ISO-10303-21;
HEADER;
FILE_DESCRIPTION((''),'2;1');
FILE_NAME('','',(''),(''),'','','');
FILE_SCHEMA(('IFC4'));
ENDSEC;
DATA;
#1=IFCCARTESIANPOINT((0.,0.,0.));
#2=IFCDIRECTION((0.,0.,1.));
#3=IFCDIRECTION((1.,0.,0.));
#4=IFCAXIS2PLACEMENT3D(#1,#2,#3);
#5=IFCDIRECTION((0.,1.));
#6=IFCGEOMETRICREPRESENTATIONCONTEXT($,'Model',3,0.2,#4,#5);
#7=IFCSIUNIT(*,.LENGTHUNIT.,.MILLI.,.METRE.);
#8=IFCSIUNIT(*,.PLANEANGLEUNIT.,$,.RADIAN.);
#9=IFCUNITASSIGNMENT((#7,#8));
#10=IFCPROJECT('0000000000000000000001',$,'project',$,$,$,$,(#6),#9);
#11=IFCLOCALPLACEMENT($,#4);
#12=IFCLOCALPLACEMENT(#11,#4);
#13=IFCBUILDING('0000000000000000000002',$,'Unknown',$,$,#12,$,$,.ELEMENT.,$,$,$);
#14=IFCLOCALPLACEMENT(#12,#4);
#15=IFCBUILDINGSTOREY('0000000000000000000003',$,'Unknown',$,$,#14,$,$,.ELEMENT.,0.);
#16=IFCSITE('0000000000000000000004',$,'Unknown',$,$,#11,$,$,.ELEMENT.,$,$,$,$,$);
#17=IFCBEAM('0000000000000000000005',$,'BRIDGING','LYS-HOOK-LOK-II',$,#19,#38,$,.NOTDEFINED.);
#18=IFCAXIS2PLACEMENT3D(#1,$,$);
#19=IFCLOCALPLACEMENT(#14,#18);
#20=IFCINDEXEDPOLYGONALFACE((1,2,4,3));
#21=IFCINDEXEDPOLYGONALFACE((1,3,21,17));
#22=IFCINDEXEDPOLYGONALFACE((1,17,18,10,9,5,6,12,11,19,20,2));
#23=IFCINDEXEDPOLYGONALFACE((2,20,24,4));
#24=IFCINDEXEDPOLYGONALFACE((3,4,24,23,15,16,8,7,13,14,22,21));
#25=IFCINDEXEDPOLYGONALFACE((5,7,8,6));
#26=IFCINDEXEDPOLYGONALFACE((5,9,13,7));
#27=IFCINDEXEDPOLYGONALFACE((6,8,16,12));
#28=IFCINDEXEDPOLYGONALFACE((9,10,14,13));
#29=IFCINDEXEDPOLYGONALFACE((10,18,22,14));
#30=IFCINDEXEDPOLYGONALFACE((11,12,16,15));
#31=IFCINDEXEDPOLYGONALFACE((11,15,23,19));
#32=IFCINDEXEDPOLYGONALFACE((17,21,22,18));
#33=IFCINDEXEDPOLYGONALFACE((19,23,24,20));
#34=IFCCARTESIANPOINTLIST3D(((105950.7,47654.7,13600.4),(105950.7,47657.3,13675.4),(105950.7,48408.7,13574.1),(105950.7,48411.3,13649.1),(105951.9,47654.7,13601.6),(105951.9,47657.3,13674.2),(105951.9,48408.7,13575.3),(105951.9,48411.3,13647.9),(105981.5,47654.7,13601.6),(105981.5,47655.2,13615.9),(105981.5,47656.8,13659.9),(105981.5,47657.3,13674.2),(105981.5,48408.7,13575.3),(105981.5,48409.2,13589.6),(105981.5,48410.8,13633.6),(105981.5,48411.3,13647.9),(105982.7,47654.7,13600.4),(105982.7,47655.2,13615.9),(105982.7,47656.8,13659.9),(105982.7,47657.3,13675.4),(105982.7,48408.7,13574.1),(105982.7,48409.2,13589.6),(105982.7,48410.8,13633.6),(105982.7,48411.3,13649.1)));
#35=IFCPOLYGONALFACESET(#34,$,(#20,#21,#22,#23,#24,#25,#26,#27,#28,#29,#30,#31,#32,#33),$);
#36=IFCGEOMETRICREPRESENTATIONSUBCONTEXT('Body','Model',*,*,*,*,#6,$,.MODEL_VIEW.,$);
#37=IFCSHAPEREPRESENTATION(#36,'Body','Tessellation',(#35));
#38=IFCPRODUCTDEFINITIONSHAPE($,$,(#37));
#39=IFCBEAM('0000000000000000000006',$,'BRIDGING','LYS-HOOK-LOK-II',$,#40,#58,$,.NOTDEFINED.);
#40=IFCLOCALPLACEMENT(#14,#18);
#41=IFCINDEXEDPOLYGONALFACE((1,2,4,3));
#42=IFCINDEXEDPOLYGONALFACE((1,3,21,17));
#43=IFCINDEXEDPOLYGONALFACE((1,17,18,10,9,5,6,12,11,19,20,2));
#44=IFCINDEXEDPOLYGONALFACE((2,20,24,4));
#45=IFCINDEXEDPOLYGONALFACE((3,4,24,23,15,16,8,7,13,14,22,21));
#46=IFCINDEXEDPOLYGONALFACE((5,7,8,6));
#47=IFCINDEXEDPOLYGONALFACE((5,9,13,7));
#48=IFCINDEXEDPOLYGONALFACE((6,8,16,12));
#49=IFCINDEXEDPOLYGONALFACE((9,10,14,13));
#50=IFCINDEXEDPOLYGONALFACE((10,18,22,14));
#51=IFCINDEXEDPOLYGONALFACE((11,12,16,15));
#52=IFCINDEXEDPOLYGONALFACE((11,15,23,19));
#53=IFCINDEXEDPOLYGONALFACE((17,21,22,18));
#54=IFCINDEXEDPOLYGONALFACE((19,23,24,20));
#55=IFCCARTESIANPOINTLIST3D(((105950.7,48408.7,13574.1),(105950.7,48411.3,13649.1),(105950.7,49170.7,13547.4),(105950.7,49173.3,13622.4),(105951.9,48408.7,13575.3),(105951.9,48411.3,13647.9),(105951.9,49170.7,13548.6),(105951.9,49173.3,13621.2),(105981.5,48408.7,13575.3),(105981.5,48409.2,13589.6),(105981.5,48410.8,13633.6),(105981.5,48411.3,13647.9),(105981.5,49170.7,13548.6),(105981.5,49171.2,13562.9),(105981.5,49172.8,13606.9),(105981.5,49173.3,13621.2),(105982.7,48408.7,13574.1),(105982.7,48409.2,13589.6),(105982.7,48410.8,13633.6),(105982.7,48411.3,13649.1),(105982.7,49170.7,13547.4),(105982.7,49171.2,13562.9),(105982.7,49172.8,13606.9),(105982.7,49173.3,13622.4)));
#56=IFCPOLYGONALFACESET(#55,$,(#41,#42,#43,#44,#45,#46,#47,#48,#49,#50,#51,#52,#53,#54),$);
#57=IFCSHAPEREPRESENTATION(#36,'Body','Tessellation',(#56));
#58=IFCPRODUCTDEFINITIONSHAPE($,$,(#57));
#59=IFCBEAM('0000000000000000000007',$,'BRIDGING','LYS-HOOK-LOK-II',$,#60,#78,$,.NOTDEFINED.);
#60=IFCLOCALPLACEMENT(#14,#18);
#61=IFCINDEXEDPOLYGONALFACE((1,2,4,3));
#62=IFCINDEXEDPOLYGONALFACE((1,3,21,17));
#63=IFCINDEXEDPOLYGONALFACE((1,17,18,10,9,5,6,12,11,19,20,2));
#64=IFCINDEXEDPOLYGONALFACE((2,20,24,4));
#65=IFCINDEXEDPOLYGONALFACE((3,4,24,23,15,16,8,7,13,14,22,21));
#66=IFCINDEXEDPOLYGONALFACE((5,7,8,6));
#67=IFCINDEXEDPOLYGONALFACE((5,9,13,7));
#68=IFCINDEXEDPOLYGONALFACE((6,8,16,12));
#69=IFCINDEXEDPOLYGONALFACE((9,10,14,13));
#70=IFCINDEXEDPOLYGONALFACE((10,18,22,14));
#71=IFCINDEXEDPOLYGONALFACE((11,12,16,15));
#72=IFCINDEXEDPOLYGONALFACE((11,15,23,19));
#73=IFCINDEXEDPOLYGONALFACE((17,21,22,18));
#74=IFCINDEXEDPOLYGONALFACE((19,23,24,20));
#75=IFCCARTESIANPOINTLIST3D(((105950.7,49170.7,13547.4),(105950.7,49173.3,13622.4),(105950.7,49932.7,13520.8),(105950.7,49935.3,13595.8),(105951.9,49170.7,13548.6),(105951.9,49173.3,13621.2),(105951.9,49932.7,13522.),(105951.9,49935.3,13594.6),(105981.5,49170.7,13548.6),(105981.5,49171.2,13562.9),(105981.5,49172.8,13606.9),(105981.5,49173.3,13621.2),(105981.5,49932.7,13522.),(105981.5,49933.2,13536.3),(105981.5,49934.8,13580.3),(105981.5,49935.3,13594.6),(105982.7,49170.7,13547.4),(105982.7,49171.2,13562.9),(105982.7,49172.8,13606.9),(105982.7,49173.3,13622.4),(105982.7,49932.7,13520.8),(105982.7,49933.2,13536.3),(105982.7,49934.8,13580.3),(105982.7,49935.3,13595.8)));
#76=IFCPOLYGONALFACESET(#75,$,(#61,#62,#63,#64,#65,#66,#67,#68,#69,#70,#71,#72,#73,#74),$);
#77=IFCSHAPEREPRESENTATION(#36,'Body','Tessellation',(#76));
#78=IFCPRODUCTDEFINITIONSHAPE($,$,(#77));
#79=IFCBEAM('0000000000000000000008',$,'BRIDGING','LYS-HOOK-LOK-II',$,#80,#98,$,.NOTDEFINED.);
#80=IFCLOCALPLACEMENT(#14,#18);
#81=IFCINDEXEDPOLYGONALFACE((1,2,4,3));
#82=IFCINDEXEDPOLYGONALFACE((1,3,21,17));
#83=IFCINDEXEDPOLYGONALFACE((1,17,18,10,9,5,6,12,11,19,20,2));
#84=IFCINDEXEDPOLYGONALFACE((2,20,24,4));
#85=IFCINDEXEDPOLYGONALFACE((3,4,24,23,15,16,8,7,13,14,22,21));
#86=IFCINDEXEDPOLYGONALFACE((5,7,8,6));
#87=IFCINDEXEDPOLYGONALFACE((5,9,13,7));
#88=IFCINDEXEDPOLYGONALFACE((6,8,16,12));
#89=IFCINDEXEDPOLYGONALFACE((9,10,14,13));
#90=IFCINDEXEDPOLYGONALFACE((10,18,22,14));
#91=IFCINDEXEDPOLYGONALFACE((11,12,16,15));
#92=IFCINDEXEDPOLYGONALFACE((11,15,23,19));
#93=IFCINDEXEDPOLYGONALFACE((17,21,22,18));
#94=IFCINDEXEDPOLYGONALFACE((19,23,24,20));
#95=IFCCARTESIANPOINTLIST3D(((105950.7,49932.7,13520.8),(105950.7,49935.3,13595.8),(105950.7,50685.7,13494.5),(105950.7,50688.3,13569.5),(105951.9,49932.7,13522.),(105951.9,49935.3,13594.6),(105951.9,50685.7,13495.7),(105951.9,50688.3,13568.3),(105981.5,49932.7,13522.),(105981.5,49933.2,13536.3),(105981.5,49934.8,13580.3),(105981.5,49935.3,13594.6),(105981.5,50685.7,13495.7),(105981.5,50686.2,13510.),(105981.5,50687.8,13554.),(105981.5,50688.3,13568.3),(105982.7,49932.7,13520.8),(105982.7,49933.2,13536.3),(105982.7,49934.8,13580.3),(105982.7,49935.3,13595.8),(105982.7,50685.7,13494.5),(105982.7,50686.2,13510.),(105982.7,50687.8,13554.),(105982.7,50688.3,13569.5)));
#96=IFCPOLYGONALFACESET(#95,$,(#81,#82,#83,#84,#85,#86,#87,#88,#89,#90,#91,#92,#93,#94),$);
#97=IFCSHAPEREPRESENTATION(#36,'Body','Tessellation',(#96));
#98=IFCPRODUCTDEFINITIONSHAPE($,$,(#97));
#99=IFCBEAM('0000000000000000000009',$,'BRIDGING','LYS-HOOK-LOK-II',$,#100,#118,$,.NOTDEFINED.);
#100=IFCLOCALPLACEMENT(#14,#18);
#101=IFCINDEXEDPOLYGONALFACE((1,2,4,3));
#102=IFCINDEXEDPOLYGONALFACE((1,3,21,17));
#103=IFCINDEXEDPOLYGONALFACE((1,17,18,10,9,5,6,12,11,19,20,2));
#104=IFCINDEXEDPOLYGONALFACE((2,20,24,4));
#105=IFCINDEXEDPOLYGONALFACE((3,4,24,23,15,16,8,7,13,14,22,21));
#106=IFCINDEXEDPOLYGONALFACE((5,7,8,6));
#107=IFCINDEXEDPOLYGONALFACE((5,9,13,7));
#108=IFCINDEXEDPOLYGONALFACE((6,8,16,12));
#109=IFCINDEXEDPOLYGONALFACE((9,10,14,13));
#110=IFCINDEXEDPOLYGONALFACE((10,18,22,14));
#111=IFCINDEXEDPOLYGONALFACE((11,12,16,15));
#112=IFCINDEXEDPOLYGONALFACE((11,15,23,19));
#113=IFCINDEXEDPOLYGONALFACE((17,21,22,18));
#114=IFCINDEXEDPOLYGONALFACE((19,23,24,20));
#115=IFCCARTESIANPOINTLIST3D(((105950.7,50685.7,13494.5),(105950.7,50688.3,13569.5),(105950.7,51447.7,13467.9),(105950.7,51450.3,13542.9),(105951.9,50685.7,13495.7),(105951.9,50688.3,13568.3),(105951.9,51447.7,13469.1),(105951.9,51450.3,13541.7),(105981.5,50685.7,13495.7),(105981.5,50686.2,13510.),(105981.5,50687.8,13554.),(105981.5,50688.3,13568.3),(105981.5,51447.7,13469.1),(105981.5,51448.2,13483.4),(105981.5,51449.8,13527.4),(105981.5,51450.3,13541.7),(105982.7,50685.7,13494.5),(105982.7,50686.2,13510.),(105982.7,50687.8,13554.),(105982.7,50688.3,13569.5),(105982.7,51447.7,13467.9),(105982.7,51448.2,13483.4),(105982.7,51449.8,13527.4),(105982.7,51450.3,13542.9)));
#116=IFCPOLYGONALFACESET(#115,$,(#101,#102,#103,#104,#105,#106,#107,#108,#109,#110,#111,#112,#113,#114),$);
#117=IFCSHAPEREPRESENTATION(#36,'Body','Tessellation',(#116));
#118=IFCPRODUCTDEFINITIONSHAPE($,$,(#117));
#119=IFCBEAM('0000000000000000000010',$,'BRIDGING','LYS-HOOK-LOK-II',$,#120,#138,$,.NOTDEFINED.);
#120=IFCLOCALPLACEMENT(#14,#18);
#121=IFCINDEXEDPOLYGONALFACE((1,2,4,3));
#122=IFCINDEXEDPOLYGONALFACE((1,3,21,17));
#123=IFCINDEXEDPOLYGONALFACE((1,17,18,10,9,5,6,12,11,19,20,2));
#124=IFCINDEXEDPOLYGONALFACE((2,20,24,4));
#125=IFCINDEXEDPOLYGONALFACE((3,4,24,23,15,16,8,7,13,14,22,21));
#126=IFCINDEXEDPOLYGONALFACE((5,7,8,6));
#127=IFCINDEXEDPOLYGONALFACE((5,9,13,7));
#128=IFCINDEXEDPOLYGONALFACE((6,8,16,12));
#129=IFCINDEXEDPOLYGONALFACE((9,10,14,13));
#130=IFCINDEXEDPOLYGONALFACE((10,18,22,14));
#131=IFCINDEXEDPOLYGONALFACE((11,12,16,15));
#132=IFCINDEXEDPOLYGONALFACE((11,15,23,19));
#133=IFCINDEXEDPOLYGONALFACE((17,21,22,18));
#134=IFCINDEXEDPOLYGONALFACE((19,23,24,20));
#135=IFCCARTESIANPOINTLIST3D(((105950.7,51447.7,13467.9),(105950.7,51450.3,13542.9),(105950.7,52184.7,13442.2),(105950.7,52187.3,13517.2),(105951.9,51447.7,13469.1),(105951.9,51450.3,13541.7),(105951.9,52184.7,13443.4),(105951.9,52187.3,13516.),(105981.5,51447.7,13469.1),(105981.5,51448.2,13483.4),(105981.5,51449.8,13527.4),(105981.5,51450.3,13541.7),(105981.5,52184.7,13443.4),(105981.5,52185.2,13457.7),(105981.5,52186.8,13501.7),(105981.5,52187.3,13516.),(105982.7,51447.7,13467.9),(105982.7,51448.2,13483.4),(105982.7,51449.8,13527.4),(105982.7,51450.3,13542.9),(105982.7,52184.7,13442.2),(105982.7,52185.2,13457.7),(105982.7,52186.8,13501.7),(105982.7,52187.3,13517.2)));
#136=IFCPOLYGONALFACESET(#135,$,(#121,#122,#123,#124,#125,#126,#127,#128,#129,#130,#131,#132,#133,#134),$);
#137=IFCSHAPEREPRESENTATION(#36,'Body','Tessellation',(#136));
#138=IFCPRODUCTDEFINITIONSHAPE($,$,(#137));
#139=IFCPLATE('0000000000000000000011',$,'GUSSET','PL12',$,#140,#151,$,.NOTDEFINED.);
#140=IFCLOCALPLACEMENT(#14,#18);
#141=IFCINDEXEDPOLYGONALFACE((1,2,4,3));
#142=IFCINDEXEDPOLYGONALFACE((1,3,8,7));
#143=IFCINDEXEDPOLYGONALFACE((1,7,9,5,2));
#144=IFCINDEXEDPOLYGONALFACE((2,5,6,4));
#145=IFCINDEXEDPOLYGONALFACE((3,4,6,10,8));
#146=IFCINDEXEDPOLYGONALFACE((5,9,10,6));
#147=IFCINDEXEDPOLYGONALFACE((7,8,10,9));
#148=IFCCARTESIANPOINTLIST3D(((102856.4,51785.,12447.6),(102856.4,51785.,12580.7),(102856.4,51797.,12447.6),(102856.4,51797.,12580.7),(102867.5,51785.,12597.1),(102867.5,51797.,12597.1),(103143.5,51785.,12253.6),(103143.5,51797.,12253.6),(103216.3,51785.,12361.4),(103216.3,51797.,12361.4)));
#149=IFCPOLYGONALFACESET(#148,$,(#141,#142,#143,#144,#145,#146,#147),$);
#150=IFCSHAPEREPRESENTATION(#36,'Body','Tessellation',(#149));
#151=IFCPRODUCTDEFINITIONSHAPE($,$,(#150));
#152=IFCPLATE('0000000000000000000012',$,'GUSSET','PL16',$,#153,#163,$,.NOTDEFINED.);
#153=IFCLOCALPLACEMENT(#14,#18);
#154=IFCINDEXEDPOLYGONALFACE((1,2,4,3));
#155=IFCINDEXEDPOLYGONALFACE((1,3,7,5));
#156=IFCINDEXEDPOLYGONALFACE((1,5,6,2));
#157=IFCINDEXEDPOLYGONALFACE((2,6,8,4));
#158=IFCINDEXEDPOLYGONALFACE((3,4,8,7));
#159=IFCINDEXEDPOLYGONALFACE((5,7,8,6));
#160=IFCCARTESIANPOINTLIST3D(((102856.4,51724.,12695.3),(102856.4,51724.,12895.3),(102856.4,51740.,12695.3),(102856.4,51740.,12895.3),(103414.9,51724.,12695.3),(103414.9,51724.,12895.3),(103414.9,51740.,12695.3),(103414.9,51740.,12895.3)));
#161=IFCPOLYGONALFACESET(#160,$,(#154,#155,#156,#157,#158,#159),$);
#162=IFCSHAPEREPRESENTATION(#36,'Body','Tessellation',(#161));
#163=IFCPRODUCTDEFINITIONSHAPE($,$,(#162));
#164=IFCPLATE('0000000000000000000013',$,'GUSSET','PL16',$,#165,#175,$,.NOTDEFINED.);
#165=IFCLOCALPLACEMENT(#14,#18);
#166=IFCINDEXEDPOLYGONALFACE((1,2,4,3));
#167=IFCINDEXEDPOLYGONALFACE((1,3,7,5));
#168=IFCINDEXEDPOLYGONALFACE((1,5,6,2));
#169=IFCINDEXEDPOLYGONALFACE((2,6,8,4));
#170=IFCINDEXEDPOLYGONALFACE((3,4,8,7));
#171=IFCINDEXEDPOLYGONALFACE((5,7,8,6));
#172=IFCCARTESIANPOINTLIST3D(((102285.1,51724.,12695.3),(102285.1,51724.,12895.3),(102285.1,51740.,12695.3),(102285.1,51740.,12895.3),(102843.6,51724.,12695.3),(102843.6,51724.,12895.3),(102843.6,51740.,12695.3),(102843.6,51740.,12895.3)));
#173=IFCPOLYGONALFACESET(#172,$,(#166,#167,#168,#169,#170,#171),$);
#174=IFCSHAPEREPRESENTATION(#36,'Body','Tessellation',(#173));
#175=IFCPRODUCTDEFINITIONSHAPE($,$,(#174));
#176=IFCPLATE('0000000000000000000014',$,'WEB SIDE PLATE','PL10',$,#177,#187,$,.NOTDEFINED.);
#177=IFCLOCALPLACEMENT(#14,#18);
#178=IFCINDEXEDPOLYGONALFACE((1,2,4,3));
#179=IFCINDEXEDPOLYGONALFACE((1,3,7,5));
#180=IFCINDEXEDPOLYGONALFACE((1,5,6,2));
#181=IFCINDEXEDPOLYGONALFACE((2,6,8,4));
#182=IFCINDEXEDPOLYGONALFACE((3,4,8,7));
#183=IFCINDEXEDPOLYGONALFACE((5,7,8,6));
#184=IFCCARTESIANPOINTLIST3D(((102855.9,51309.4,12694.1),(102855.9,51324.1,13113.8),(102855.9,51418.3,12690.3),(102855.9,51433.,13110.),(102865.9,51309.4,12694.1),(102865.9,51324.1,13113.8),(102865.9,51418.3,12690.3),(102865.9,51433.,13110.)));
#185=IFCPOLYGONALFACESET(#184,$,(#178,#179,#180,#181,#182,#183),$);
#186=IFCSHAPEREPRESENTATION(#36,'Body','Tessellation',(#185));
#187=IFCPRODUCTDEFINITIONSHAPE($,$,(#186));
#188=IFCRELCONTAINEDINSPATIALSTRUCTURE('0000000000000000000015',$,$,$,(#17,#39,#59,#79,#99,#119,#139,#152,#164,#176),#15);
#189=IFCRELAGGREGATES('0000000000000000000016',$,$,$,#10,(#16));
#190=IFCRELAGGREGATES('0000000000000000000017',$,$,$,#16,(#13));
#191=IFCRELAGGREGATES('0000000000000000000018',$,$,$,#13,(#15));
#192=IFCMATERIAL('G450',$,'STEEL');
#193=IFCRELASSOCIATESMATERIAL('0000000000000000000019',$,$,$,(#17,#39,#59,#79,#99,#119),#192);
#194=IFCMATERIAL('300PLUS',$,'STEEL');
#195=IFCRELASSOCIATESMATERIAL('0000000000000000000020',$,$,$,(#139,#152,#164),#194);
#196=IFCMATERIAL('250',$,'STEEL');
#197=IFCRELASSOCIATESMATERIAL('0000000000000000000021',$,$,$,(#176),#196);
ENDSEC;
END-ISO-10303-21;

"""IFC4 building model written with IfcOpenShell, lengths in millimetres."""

from ifc_helpers import new_model, si_unit, direction, frame, origin_with_axes, place, context, subcontext, project, spatial, line, indexed_curve, outline, extrude, material, element, save


model = new_model("IFC4")

# Units and contexts
model_context = context("Model", 3, precision=0.2, world=origin_with_axes(), true_north=direction((0.0, 1.0)))
body_context = subcontext(model_context, "Body", "Model", "MODEL_VIEW")
ifc_project = project(units=[si_unit("LENGTHUNIT", "METRE", prefix="MILLI"), si_unit("PLANEANGLEUNIT", "RADIAN")], contexts=[model_context])

# Site, building, storey
site_placement = place(None, origin_with_axes())
site = spatial("IfcSite", under=ifc_project, at=site_placement, Name="Unknown", CompositionType="ELEMENT")
building_placement = place(site_placement, origin_with_axes())
building = spatial("IfcBuilding", under=site, at=building_placement, Name="Unknown", CompositionType="ELEMENT")
storey_placement = place(building_placement, origin_with_axes())
storey = spatial("IfcBuildingStorey", under=building, at=storey_placement, Name="Unknown", CompositionType="ELEMENT", Elevation=0.0)

# Shared definitions
ifc_material_1 = material(Name="300PLUS", Category="STEEL")
ifc_material_2 = material(Name="G450", Category="STEEL")

# Beams
beam_1_placement = place(storey_placement, frame((105966.7, 47656.0, 13637.9), z_axis=(1.0, 0.0, 0.0), x_axis=(0.0, 0.999392, -0.034859)))
element("IfcBeam", 1, at=beam_1_placement, inside=storey, material=ifc_material_2, Name="BRIDGING", Description="LYS-HOOK-LOK-II", PredefinedType="NOTDEFINED", context=body_context, shape_type="SolidModel", body=[
    extrude(outline(indexed_curve([(16.0, -37.5), (16.0, -22.0), (14.8, -22.0), (14.8, -36.3), (-14.8, -36.3), (-14.8, 36.3), (14.8, 36.3), (14.8, 22.0), (16.0, 22.0), (16.0, 37.5), (-16.0, 37.5), (-16.0, -37.5)], segments=[line(1, 2, 3, 4, 5, 6, 7, 8, 9, 10, 11, 12, 1)])), frame((0.0, 0.0, 0.0), z_axis=(-1.0, 0.0, 0.0), x_axis=(0.0, 0.0, 1.0)), (0.0, 0.0, -1.0), 754.5),
])
beam_2_placement = place(storey_placement, frame((105966.7, 48410.0, 13611.6), z_axis=(1.0, 0.0, 0.0), x_axis=(0.0, 0.999387, -0.035018)))
element("IfcBeam", 2, at=beam_2_placement, inside=storey, material=ifc_material_2, Name="BRIDGING", Description="LYS-HOOK-LOK-II", PredefinedType="NOTDEFINED", context=body_context, shape_type="SolidModel", body=[
    extrude(outline(indexed_curve([(16.0, -37.5), (16.0, -22.0), (14.8, -22.0), (14.8, -36.3), (-14.8, -36.3), (-14.8, 36.3), (14.8, 36.3), (14.8, 22.0), (16.0, 22.0), (16.0, 37.5), (-16.0, 37.5), (-16.0, -37.5)], segments=[line(1, 2, 3, 4, 5, 6, 7, 8, 9, 10, 11, 12, 1)])), frame((0.0, 0.0, 0.0), z_axis=(-1.0, 0.0, 0.0), x_axis=(0.0, 0.0, 1.0)), (0.0, 0.0, -1.0), 762.5),
])
beam_3_placement = place(storey_placement, frame((105966.7, 49172.0, 13584.9), z_axis=(1.0, 0.0, 0.0), x_axis=(0.0, 0.999391, -0.034887)))
element("IfcBeam", 3, at=beam_3_placement, inside=storey, material=ifc_material_2, Name="BRIDGING", Description="LYS-HOOK-LOK-II", PredefinedType="NOTDEFINED", context=body_context, shape_type="SolidModel", body=[
    extrude(outline(indexed_curve([(16.0, -37.5), (16.0, -22.0), (14.8, -22.0), (14.8, -36.3), (-14.8, -36.3), (-14.8, 36.3), (14.8, 36.3), (14.8, 22.0), (16.0, 22.0), (16.0, 37.5), (-16.0, 37.5), (-16.0, -37.5)], segments=[line(1, 2, 3, 4, 5, 6, 7, 8, 9, 10, 11, 12, 1)])), frame((0.0, 0.0, 0.0), z_axis=(-1.0, 0.0, 0.0), x_axis=(0.0, 0.0, 1.0)), (0.0, 0.0, -1.0), 762.5),
])
beam_4_placement = place(storey_placement, frame((105966.7, 49934.0, 13558.3), z_axis=(1.0, 0.0, 0.0), x_axis=(0.0, 0.999391, -0.034906)))
element("IfcBeam", 4, at=beam_4_placement, inside=storey, material=ifc_material_2, Name="BRIDGING", Description="LYS-HOOK-LOK-II", PredefinedType="NOTDEFINED", context=body_context, shape_type="SolidModel", body=[
    extrude(outline(indexed_curve([(16.0, -37.5), (16.0, -22.0), (14.8, -22.0), (14.8, -36.3), (-14.8, -36.3), (-14.8, 36.3), (14.8, 36.3), (14.8, 22.0), (16.0, 22.0), (16.0, 37.5), (-16.0, 37.5), (-16.0, -37.5)], segments=[line(1, 2, 3, 4, 5, 6, 7, 8, 9, 10, 11, 12, 1)])), frame((0.0, 0.0, 0.0), z_axis=(-1.0, 0.0, 0.0), x_axis=(0.0, 0.0, 1.0)), (0.0, 0.0, -1.0), 753.5),
])
beam_5_placement = place(storey_placement, frame((105966.7, 50687.0, 13532.0), z_axis=(1.0, 0.0, 0.0), x_axis=(0.0, 0.999391, -0.034887)))
element("IfcBeam", 5, at=beam_5_placement, inside=storey, material=ifc_material_2, Name="BRIDGING", Description="LYS-HOOK-LOK-II", PredefinedType="NOTDEFINED", context=body_context, shape_type="SolidModel", body=[
    extrude(outline(indexed_curve([(16.0, -37.5), (16.0, -22.0), (14.8, -22.0), (14.8, -36.3), (-14.8, -36.3), (-14.8, 36.3), (14.8, 36.3), (14.8, 22.0), (16.0, 22.0), (16.0, 37.5), (-16.0, 37.5), (-16.0, -37.5)], segments=[line(1, 2, 3, 4, 5, 6, 7, 8, 9, 10, 11, 12, 1)])), frame((0.0, 0.0, 0.0), z_axis=(-1.0, 0.0, 0.0), x_axis=(0.0, 0.0, 1.0)), (0.0, 0.0, -1.0), 762.5),
])
beam_6_placement = place(storey_placement, frame((105966.7, 51449.0, 13505.4), z_axis=(1.0, 0.0, 0.0), x_axis=(0.0, 0.999393, -0.03485)))
element("IfcBeam", 6, at=beam_6_placement, inside=storey, material=ifc_material_2, Name="BRIDGING", Description="LYS-HOOK-LOK-II", PredefinedType="NOTDEFINED", context=body_context, shape_type="SolidModel", body=[
    extrude(outline(indexed_curve([(16.0, -37.5), (16.0, -22.0), (14.8, -22.0), (14.8, -36.3), (-14.8, -36.3), (-14.8, 36.3), (14.8, 36.3), (14.8, 22.0), (16.0, 22.0), (16.0, 37.5), (-16.0, 37.5), (-16.0, -37.5)], segments=[line(1, 2, 3, 4, 5, 6, 7, 8, 9, 10, 11, 12, 1)])), frame((0.0, 0.0, 0.0), z_axis=(-1.0, 0.0, 0.0), x_axis=(0.0, 0.0, 1.0)), (0.0, 0.0, -1.0), 737.4),
])

# Plates
plate_1_placement = place(storey_placement, frame((102856.4, 51791.0, 12580.7), z_axis=(0.0, 1.0, 0.0), x_axis=(0.560513, 0.0, 0.828146)))
element("IfcPlate", 7, at=plate_1_placement, inside=storey, material=ifc_material_1, Name="GUSSET", Description="PL12", PredefinedType="NOTDEFINED", context=body_context, shape_type="SolidModel", body=[
    extrude(outline(indexed_curve([(0.0, 0.0), (19.8, 0.0), (20.1, 421.0), (-110.0, 421.1), (-110.2, 74.6)], segments=[line(1, 2, 3, 4, 5, 1)])), frame((0.0, 0.0, 6.0), z_axis=(0.0, 0.0, 1.0), x_axis=(1.0, 0.0, 0.0)), (0.0, 0.0, -1.0), 12.0),
])
for number, where, z_axis, x_axis, name in (
    (8, (102856.4, 51732.0, 12695.3), (0.0, -1.0, 0.0), (1.0, 0.0, 0.0), "GUSSET"),
    (9, (102843.6, 51732.0, 12895.3), (0.0, -1.0, 0.0), (-1.0, 0.0, 0.0), "GUSSET"),
):
    element("IfcPlate", number, at=place(storey_placement, frame(where, z_axis=z_axis, x_axis=x_axis)), inside=storey, material=ifc_material_1, Name=name, Description="PL16", PredefinedType="NOTDEFINED", context=body_context, shape_type="SolidModel", body=[
        extrude(outline(indexed_curve([(0.0, 0.0), (558.5, 0.0), (558.5, 200.0), (0.0, 200.0)], segments=[line(1, 2, 3, 4, 1)])), frame((0.0, 0.0, 8.0), z_axis=(0.0, 0.0, 1.0), x_axis=(1.0, 0.0, 0.0)), (0.0, 0.0, -1.0), 16.0),
    ])
ifc_material_3 = material(Name="250", Category="STEEL")
plate_2_placement = place(storey_placement, frame((102860.9, 51433.0, 13110.0), z_axis=(1.0, 0.0, 0.0), x_axis=(0.0, -0.999392, 0.034873)))
element("IfcPlate", 10, at=plate_2_placement, inside=storey, material=ifc_material_3, Name="WEB SIDE PLATE", Description="PL10", PredefinedType="NOTDEFINED", context=body_context, shape_type="SolidModel", body=[
    extrude(outline(indexed_curve([(0.0, 0.0), (109.0, 0.0), (109.0, 420.0), (0.1, 420.0)], segments=[line(1, 2, 3, 4, 1)])), frame((0.0, 0.0, 5.0), z_axis=(0.0, 0.0, 1.0), x_axis=(1.0, 0.0, 0.0)), (0.0, 0.0, -1.0), 10.0),
])

save(model, "model.ifc")
